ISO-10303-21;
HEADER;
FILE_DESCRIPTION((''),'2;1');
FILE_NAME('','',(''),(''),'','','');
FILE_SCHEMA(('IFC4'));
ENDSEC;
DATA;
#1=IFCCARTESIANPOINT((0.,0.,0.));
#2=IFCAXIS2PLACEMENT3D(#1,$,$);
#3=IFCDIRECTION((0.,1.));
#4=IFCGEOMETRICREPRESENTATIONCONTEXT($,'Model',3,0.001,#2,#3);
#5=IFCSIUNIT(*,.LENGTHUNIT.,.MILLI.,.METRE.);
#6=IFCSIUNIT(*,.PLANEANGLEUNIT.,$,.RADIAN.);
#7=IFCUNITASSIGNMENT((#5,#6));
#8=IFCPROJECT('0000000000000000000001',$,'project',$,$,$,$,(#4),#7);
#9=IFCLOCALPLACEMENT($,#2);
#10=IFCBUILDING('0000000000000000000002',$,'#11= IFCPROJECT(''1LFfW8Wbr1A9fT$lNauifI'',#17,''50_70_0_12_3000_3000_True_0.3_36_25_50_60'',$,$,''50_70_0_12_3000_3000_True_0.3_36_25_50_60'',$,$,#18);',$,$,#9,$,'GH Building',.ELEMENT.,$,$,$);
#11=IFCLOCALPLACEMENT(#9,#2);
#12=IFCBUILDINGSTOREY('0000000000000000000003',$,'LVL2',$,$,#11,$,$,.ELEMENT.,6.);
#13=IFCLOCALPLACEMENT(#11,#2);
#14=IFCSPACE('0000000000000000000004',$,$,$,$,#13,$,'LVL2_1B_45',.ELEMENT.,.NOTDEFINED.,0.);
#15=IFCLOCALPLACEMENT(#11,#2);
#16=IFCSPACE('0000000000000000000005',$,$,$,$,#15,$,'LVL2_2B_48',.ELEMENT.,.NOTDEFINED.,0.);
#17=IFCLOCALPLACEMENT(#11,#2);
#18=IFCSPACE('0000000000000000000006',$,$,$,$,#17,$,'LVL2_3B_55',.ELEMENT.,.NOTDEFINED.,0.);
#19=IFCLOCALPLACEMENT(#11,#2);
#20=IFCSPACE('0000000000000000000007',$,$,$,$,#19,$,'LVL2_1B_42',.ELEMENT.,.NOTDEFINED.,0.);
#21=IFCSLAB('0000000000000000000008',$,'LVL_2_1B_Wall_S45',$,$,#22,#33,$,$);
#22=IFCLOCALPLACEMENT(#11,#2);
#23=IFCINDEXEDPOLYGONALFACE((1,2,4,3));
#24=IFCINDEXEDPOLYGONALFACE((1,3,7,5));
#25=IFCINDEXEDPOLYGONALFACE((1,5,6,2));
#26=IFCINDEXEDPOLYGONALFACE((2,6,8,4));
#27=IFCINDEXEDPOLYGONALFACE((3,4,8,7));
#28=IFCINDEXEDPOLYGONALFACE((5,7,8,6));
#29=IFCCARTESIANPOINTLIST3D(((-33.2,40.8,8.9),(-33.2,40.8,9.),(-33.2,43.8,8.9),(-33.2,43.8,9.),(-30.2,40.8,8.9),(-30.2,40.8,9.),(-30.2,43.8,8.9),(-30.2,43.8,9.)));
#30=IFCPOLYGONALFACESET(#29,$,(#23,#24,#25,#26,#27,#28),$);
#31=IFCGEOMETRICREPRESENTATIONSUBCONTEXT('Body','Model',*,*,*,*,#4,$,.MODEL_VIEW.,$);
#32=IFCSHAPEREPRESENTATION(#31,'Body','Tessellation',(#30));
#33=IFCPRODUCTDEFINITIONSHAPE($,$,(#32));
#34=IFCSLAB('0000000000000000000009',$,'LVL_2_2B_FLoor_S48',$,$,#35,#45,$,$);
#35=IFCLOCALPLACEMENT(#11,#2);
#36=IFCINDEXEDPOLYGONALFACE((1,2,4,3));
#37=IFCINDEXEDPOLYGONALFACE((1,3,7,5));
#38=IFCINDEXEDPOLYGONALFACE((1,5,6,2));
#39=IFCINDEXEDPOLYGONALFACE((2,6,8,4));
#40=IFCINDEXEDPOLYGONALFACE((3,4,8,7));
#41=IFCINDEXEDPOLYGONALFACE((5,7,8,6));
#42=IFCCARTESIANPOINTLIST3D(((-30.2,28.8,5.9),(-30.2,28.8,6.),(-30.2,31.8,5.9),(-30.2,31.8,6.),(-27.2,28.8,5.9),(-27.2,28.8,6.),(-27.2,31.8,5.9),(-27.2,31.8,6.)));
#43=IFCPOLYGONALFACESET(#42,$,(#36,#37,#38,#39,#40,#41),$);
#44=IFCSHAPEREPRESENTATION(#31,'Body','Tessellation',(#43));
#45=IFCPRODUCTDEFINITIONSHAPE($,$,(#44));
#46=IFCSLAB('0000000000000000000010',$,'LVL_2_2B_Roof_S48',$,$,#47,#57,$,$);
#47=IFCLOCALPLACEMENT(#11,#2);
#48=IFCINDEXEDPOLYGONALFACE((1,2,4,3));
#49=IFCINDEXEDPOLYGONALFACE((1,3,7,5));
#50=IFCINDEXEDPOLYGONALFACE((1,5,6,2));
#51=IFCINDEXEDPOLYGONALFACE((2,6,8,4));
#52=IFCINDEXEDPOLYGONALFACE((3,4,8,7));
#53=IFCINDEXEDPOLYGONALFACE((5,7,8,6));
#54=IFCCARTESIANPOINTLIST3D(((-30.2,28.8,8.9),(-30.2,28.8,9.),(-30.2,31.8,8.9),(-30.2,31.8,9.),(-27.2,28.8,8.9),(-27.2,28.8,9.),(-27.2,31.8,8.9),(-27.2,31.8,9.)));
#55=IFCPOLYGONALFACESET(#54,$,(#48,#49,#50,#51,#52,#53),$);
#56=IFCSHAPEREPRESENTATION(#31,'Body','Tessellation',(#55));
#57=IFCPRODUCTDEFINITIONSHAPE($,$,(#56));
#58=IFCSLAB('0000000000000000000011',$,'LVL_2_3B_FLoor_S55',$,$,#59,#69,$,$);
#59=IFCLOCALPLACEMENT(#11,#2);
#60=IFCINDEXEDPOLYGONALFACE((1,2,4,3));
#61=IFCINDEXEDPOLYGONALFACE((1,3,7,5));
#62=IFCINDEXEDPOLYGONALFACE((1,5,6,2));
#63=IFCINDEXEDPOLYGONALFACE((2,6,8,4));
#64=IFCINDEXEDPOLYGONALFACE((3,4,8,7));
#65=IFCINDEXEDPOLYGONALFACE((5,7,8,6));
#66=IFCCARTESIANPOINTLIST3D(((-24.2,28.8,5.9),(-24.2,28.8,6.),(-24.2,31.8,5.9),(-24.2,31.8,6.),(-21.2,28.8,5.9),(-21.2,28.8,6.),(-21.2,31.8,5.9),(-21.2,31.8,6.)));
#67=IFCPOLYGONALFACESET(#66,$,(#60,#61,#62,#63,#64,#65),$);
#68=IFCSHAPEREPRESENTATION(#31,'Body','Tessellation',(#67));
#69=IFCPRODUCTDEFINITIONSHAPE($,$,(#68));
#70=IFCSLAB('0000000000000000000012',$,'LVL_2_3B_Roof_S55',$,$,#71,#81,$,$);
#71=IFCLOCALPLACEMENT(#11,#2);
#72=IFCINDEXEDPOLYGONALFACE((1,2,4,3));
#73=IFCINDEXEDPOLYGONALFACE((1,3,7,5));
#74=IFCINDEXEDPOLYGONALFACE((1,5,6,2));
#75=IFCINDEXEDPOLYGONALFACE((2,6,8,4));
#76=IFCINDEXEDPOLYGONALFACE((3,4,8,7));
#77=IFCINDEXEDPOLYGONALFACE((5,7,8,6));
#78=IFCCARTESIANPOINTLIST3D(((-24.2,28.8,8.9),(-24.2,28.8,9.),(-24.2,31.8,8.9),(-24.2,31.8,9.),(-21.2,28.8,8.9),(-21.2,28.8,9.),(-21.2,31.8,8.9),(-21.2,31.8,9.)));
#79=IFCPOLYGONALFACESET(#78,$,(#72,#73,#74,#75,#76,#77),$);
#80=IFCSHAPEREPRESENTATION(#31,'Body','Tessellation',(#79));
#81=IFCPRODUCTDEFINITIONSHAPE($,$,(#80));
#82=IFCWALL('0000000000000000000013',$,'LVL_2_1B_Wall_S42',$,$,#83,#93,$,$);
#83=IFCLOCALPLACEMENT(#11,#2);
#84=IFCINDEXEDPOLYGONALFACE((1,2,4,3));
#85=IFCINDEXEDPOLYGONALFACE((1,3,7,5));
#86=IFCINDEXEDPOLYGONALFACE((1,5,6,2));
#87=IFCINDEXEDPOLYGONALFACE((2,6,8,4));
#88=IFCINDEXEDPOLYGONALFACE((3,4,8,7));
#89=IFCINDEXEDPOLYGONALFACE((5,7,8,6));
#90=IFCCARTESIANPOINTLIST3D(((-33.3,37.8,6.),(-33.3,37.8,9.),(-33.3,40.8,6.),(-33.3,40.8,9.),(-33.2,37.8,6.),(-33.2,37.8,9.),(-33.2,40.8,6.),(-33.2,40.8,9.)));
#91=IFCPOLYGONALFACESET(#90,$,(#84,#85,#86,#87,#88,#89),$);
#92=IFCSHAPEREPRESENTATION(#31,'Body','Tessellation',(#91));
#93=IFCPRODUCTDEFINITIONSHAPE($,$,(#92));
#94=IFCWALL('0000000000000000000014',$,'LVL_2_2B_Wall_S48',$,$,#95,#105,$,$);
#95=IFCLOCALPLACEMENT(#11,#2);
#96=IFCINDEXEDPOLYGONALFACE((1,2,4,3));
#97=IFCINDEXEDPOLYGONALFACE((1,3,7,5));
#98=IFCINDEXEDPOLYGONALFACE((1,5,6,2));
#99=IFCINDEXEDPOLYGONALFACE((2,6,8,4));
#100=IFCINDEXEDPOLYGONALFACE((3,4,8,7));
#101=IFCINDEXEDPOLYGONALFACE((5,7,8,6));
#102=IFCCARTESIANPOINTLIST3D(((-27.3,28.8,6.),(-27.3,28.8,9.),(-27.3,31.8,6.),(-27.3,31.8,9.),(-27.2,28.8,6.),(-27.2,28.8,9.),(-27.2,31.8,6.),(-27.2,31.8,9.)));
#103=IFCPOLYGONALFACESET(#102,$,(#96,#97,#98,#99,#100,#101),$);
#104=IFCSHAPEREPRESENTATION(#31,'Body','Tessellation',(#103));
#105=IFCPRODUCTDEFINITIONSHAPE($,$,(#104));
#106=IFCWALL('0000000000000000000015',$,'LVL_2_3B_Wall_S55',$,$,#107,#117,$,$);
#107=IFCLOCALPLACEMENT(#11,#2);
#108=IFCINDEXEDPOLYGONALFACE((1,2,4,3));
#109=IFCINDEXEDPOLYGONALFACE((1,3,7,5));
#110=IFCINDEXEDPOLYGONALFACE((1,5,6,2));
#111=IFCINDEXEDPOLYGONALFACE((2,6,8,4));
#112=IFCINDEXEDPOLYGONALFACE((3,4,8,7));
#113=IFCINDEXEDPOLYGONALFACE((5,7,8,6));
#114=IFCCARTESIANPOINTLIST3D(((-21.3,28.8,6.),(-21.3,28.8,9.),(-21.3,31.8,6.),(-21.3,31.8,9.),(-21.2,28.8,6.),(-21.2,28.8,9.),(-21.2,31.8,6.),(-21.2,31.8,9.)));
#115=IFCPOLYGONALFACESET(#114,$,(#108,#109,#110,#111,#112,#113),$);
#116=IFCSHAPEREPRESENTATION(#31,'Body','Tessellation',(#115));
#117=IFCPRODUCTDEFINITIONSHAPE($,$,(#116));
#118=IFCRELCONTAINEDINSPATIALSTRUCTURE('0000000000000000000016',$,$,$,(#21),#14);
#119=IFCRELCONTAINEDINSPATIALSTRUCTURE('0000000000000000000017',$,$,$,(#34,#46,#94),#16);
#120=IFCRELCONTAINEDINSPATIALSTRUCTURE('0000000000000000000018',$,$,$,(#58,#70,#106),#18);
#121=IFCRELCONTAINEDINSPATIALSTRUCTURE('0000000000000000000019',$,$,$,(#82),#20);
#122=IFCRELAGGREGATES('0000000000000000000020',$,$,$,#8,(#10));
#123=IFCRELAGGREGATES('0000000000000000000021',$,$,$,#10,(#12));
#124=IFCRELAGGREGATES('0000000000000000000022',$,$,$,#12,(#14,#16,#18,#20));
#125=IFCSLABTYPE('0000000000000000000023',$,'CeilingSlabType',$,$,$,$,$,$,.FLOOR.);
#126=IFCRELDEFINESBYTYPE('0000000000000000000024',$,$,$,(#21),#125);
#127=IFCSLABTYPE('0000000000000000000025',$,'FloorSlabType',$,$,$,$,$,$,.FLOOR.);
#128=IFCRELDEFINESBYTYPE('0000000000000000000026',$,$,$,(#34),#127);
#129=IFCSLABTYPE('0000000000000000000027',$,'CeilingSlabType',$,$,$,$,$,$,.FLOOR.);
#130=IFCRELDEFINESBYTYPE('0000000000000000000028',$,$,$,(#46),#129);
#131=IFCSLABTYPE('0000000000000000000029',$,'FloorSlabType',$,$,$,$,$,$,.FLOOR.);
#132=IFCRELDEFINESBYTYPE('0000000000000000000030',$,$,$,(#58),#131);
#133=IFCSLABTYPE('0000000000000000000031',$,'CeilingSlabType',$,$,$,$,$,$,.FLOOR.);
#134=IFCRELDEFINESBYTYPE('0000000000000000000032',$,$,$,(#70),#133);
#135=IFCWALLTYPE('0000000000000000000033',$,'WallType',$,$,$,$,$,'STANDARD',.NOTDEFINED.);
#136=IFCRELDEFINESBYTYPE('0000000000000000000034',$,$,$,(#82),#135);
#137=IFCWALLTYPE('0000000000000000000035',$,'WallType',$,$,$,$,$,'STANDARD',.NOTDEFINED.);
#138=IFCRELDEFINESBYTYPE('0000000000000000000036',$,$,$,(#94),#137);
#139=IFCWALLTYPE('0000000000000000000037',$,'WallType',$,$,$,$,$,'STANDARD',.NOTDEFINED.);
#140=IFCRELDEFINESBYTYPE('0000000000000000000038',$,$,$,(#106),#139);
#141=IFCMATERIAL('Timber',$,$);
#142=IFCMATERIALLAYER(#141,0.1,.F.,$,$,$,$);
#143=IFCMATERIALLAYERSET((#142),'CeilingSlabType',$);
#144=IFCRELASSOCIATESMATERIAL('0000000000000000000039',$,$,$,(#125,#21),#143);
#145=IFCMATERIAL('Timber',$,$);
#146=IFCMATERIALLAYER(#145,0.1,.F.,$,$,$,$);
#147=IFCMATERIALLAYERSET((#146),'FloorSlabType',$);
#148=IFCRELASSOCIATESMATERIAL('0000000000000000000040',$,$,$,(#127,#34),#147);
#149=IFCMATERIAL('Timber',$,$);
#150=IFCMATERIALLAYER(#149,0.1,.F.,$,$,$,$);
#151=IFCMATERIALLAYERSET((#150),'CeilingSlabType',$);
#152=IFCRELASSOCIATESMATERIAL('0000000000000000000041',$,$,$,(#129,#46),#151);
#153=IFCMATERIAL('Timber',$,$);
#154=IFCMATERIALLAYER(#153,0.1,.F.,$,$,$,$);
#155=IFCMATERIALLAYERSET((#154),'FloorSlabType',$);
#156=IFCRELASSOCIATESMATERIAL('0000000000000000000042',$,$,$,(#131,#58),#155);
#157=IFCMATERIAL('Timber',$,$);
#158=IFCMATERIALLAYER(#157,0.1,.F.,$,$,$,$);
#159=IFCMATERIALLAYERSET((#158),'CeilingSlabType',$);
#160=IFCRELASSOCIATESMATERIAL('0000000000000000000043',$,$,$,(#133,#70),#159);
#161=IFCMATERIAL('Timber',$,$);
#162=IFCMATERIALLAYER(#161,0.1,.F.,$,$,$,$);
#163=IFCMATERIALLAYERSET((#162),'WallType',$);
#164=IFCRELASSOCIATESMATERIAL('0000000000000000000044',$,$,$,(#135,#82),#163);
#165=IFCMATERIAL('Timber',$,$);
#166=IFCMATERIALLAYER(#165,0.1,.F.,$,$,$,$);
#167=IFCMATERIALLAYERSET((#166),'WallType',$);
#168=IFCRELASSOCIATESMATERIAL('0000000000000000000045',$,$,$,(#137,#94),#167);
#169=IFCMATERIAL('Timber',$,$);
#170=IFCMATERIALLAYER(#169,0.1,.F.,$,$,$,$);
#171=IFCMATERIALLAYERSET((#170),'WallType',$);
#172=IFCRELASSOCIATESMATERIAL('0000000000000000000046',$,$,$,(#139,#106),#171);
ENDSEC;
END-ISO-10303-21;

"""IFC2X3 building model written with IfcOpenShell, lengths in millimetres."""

from ifc_helpers import new_model, si_unit, direction, frame, frame_2d, origin, place, context, subcontext, project, spatial, rectangle, extrude, material, layer, layer_set, layer_usage, type_object, element, save


model = new_model("IFC2X3")

# Units and contexts
model_context = context("Model", 3, precision=0.001, world=origin(), true_north=direction((0.0, 1.0)))
body_context = subcontext(model_context, "Body", "Model", "MODEL_VIEW")
ifc_project = project(units=[si_unit("LENGTHUNIT", "METRE", prefix="MILLI"), si_unit("PLANEANGLEUNIT", "RADIAN")], contexts=[model_context])

# Building, storey
building_placement = place(None, origin())
building = spatial("IfcBuilding", under=ifc_project, at=building_placement, Name="#11= IFCPROJECT('1LFfW8Wbr1A9fT$lNauifI',#17,'50_70_0_12_3000_3000_True_0.3_36_25_50_60',$,$,'50_70_0_12_3000_3000_True_0.3_36_25_50_60',$,$,#18);", LongName="GH Building", CompositionType="ELEMENT")
storey_placement = place(building_placement, origin())
storey = spatial("IfcBuildingStorey", under=building, at=storey_placement, Name="LVL2", CompositionType="ELEMENT", Elevation=6.0)

# Shared definitions
space_1_placement = place(storey_placement, origin())
space_1 = spatial("IfcSpace", under=storey, at=space_1_placement, LongName="LVL2_1B_45", CompositionType="ELEMENT", InteriorOrExteriorSpace="NOTDEFINED", ElevationWithFlooring=0.0)

# Slab
ifc_material_1 = material(Name="Timber")
ifc_layer_1 = layer(ifc_material_1, 0.1, ventilated=False)
ifc_layer_set_1 = layer_set([ifc_layer_1], Name="CeilingSlabType")
ifc_layer_usage_1 = layer_usage(ifc_layer_set_1, "AXIS3", "NEGATIVE", -0.1)
slab_type_1 = type_object("IfcSlabType", Name="CeilingSlabType", PredefinedType="FLOOR", material=ifc_layer_set_1)
slab_1_placement = place(space_1_placement, frame((-33.2, 43.8, 8.9), z_axis=(0.0, 0.0, 1.0), x_axis=(0.0, -1.0, 0.0)))
element("IfcSlab", 1, at=slab_1_placement, inside=space_1, type_object=slab_type_1, material=ifc_layer_usage_1, Name="LVL_2_1B_Wall_S45", context=body_context, shape_type="SweptSolid", body=[
    extrude(rectangle(XDim=3.0, YDim=3.0, at=frame_2d((1.5, 1.5))), origin(), (0.0, 0.0, 1.0), 0.1),
])

# Shared definitions
space_2_placement = place(storey_placement, origin())
space_2 = spatial("IfcSpace", under=storey, at=space_2_placement, LongName="LVL2_2B_48", CompositionType="ELEMENT", InteriorOrExteriorSpace="NOTDEFINED", ElevationWithFlooring=0.0)

# Slabs
ifc_material_2 = material(Name="Timber")
ifc_layer_2 = layer(ifc_material_2, 0.1, ventilated=False)
ifc_layer_set_2 = layer_set([ifc_layer_2], Name="FloorSlabType")
ifc_layer_usage_2 = layer_usage(ifc_layer_set_2, "AXIS3", "NEGATIVE", -0.1)
slab_type_2 = type_object("IfcSlabType", Name="FloorSlabType", PredefinedType="FLOOR", material=ifc_layer_set_2)
slab_2_placement = place(space_2_placement, frame((-27.2, 31.8, 5.9), z_axis=(0.0, 0.0, 1.0), x_axis=(-1.0, 0.0, 0.0)))
element("IfcSlab", 2, at=slab_2_placement, inside=space_2, type_object=slab_type_2, material=ifc_layer_usage_2, Name="LVL_2_2B_FLoor_S48", context=body_context, shape_type="SweptSolid", body=[
    extrude(rectangle(XDim=3.0, YDim=3.0, at=frame_2d((1.5, 1.5))), origin(), (0.0, 0.0, 1.0), 0.1),
])
ifc_material_3 = material(Name="Timber")
ifc_layer_3 = layer(ifc_material_3, 0.1, ventilated=False)
ifc_layer_set_3 = layer_set([ifc_layer_3], Name="CeilingSlabType")
ifc_layer_usage_3 = layer_usage(ifc_layer_set_3, "AXIS3", "NEGATIVE", -0.1)
slab_type_3 = type_object("IfcSlabType", Name="CeilingSlabType", PredefinedType="FLOOR", material=ifc_layer_set_3)
slab_3_placement = place(space_2_placement, frame((-27.2, 31.8, 8.9), z_axis=(0.0, 0.0, 1.0), x_axis=(-1.0, 0.0, 0.0)))
element("IfcSlab", 3, at=slab_3_placement, inside=space_2, type_object=slab_type_3, material=ifc_layer_usage_3, Name="LVL_2_2B_Roof_S48", context=body_context, shape_type="SweptSolid", body=[
    extrude(rectangle(XDim=3.0, YDim=3.0, at=frame_2d((1.5, 1.5))), origin(), (0.0, 0.0, 1.0), 0.1),
])

# Shared definitions
space_3_placement = place(storey_placement, origin())
space_3 = spatial("IfcSpace", under=storey, at=space_3_placement, LongName="LVL2_3B_55", CompositionType="ELEMENT", InteriorOrExteriorSpace="NOTDEFINED", ElevationWithFlooring=0.0)

# Slabs
ifc_material_4 = material(Name="Timber")
ifc_layer_4 = layer(ifc_material_4, 0.1, ventilated=False)
ifc_layer_set_4 = layer_set([ifc_layer_4], Name="FloorSlabType")
ifc_layer_usage_4 = layer_usage(ifc_layer_set_4, "AXIS3", "NEGATIVE", -0.1)
slab_type_4 = type_object("IfcSlabType", Name="FloorSlabType", PredefinedType="FLOOR", material=ifc_layer_set_4)
slab_4_placement = place(space_3_placement, frame((-21.2, 31.8, 5.9), z_axis=(0.0, 0.0, 1.0), x_axis=(-1.0, 0.0, 0.0)))
element("IfcSlab", 4, at=slab_4_placement, inside=space_3, type_object=slab_type_4, material=ifc_layer_usage_4, Name="LVL_2_3B_FLoor_S55", context=body_context, shape_type="SweptSolid", body=[
    extrude(rectangle(XDim=3.0, YDim=3.0, at=frame_2d((1.5, 1.5))), origin(), (0.0, 0.0, 1.0), 0.1),
])
ifc_material_5 = material(Name="Timber")
ifc_layer_5 = layer(ifc_material_5, 0.1, ventilated=False)
ifc_layer_set_5 = layer_set([ifc_layer_5], Name="CeilingSlabType")
ifc_layer_usage_5 = layer_usage(ifc_layer_set_5, "AXIS3", "NEGATIVE", -0.1)
slab_type_5 = type_object("IfcSlabType", Name="CeilingSlabType", PredefinedType="FLOOR", material=ifc_layer_set_5)
slab_5_placement = place(space_3_placement, frame((-21.2, 31.8, 8.9), z_axis=(0.0, 0.0, 1.0), x_axis=(-1.0, 0.0, 0.0)))
element("IfcSlab", 5, at=slab_5_placement, inside=space_3, type_object=slab_type_5, material=ifc_layer_usage_5, Name="LVL_2_3B_Roof_S55", context=body_context, shape_type="SweptSolid", body=[
    extrude(rectangle(XDim=3.0, YDim=3.0, at=frame_2d((1.5, 1.5))), origin(), (0.0, 0.0, 1.0), 0.1),
])

# Shared definitions
space_4_placement = place(storey_placement, origin())
space_4 = spatial("IfcSpace", under=storey, at=space_4_placement, LongName="LVL2_1B_42", CompositionType="ELEMENT", InteriorOrExteriorSpace="NOTDEFINED", ElevationWithFlooring=0.0)

# Wall
ifc_material_6 = material(Name="Timber")
ifc_layer_6 = layer(ifc_material_6, 0.1, ventilated=False)
ifc_layer_set_6 = layer_set([ifc_layer_6], Name="WallType")
ifc_layer_usage_6 = layer_usage(ifc_layer_set_6, "AXIS2", "NEGATIVE", 0.0)
wall_type_1 = type_object("IfcWallType", Name="WallType", ElementType="STANDARD", PredefinedType="NOTDEFINED", material=ifc_layer_set_6)
wall_1_placement = place(space_4_placement, frame((-33.2, 40.8, 6.0), z_axis=(0.0, 0.0, 1.0), x_axis=(0.0, -1.0, 0.0)))
element("IfcWall", 6, at=wall_1_placement, inside=space_4, type_object=wall_type_1, material=ifc_layer_usage_6, Name="LVL_2_1B_Wall_S42", context=body_context, shape_type="SweptSolid", body=[
    extrude(rectangle(XDim=3.0, YDim=0.1, at=frame_2d((1.5, -0.1))), origin(), (0.0, 0.0, 1.0), 3.0),
])

# Wall
ifc_material_7 = material(Name="Timber")
ifc_layer_7 = layer(ifc_material_7, 0.1, ventilated=False)
ifc_layer_set_7 = layer_set([ifc_layer_7], Name="WallType")
ifc_layer_usage_7 = layer_usage(ifc_layer_set_7, "AXIS2", "NEGATIVE", 0.0)
wall_type_2 = type_object("IfcWallType", Name="WallType", ElementType="STANDARD", PredefinedType="NOTDEFINED", material=ifc_layer_set_7)
wall_2_placement = place(space_2_placement, frame((-27.2, 31.8, 6.0), z_axis=(0.0, 0.0, 1.0), x_axis=(0.0, -1.0, 0.0)))
element("IfcWall", 7, at=wall_2_placement, inside=space_2, type_object=wall_type_2, material=ifc_layer_usage_7, Name="LVL_2_2B_Wall_S48", context=body_context, shape_type="SweptSolid", body=[
    extrude(rectangle(XDim=3.0, YDim=0.1, at=frame_2d((1.5, -0.1))), origin(), (0.0, 0.0, 1.0), 3.0),
])

# Wall
ifc_material_8 = material(Name="Timber")
ifc_layer_8 = layer(ifc_material_8, 0.1, ventilated=False)
ifc_layer_set_8 = layer_set([ifc_layer_8], Name="WallType")
ifc_layer_usage_8 = layer_usage(ifc_layer_set_8, "AXIS2", "NEGATIVE", 0.0)
wall_type_3 = type_object("IfcWallType", Name="WallType", ElementType="STANDARD", PredefinedType="NOTDEFINED", material=ifc_layer_set_8)
wall_3_placement = place(space_3_placement, frame((-21.2, 31.8, 6.0), z_axis=(0.0, 0.0, 1.0), x_axis=(0.0, -1.0, 0.0)))
element("IfcWall", 8, at=wall_3_placement, inside=space_3, type_object=wall_type_3, material=ifc_layer_usage_8, Name="LVL_2_3B_Wall_S55", context=body_context, shape_type="SweptSolid", body=[
    extrude(rectangle(XDim=3.0, YDim=0.1, at=frame_2d((1.5, -0.1))), origin(), (0.0, 0.0, 1.0), 3.0),
])

save(model, "model.ifc")
